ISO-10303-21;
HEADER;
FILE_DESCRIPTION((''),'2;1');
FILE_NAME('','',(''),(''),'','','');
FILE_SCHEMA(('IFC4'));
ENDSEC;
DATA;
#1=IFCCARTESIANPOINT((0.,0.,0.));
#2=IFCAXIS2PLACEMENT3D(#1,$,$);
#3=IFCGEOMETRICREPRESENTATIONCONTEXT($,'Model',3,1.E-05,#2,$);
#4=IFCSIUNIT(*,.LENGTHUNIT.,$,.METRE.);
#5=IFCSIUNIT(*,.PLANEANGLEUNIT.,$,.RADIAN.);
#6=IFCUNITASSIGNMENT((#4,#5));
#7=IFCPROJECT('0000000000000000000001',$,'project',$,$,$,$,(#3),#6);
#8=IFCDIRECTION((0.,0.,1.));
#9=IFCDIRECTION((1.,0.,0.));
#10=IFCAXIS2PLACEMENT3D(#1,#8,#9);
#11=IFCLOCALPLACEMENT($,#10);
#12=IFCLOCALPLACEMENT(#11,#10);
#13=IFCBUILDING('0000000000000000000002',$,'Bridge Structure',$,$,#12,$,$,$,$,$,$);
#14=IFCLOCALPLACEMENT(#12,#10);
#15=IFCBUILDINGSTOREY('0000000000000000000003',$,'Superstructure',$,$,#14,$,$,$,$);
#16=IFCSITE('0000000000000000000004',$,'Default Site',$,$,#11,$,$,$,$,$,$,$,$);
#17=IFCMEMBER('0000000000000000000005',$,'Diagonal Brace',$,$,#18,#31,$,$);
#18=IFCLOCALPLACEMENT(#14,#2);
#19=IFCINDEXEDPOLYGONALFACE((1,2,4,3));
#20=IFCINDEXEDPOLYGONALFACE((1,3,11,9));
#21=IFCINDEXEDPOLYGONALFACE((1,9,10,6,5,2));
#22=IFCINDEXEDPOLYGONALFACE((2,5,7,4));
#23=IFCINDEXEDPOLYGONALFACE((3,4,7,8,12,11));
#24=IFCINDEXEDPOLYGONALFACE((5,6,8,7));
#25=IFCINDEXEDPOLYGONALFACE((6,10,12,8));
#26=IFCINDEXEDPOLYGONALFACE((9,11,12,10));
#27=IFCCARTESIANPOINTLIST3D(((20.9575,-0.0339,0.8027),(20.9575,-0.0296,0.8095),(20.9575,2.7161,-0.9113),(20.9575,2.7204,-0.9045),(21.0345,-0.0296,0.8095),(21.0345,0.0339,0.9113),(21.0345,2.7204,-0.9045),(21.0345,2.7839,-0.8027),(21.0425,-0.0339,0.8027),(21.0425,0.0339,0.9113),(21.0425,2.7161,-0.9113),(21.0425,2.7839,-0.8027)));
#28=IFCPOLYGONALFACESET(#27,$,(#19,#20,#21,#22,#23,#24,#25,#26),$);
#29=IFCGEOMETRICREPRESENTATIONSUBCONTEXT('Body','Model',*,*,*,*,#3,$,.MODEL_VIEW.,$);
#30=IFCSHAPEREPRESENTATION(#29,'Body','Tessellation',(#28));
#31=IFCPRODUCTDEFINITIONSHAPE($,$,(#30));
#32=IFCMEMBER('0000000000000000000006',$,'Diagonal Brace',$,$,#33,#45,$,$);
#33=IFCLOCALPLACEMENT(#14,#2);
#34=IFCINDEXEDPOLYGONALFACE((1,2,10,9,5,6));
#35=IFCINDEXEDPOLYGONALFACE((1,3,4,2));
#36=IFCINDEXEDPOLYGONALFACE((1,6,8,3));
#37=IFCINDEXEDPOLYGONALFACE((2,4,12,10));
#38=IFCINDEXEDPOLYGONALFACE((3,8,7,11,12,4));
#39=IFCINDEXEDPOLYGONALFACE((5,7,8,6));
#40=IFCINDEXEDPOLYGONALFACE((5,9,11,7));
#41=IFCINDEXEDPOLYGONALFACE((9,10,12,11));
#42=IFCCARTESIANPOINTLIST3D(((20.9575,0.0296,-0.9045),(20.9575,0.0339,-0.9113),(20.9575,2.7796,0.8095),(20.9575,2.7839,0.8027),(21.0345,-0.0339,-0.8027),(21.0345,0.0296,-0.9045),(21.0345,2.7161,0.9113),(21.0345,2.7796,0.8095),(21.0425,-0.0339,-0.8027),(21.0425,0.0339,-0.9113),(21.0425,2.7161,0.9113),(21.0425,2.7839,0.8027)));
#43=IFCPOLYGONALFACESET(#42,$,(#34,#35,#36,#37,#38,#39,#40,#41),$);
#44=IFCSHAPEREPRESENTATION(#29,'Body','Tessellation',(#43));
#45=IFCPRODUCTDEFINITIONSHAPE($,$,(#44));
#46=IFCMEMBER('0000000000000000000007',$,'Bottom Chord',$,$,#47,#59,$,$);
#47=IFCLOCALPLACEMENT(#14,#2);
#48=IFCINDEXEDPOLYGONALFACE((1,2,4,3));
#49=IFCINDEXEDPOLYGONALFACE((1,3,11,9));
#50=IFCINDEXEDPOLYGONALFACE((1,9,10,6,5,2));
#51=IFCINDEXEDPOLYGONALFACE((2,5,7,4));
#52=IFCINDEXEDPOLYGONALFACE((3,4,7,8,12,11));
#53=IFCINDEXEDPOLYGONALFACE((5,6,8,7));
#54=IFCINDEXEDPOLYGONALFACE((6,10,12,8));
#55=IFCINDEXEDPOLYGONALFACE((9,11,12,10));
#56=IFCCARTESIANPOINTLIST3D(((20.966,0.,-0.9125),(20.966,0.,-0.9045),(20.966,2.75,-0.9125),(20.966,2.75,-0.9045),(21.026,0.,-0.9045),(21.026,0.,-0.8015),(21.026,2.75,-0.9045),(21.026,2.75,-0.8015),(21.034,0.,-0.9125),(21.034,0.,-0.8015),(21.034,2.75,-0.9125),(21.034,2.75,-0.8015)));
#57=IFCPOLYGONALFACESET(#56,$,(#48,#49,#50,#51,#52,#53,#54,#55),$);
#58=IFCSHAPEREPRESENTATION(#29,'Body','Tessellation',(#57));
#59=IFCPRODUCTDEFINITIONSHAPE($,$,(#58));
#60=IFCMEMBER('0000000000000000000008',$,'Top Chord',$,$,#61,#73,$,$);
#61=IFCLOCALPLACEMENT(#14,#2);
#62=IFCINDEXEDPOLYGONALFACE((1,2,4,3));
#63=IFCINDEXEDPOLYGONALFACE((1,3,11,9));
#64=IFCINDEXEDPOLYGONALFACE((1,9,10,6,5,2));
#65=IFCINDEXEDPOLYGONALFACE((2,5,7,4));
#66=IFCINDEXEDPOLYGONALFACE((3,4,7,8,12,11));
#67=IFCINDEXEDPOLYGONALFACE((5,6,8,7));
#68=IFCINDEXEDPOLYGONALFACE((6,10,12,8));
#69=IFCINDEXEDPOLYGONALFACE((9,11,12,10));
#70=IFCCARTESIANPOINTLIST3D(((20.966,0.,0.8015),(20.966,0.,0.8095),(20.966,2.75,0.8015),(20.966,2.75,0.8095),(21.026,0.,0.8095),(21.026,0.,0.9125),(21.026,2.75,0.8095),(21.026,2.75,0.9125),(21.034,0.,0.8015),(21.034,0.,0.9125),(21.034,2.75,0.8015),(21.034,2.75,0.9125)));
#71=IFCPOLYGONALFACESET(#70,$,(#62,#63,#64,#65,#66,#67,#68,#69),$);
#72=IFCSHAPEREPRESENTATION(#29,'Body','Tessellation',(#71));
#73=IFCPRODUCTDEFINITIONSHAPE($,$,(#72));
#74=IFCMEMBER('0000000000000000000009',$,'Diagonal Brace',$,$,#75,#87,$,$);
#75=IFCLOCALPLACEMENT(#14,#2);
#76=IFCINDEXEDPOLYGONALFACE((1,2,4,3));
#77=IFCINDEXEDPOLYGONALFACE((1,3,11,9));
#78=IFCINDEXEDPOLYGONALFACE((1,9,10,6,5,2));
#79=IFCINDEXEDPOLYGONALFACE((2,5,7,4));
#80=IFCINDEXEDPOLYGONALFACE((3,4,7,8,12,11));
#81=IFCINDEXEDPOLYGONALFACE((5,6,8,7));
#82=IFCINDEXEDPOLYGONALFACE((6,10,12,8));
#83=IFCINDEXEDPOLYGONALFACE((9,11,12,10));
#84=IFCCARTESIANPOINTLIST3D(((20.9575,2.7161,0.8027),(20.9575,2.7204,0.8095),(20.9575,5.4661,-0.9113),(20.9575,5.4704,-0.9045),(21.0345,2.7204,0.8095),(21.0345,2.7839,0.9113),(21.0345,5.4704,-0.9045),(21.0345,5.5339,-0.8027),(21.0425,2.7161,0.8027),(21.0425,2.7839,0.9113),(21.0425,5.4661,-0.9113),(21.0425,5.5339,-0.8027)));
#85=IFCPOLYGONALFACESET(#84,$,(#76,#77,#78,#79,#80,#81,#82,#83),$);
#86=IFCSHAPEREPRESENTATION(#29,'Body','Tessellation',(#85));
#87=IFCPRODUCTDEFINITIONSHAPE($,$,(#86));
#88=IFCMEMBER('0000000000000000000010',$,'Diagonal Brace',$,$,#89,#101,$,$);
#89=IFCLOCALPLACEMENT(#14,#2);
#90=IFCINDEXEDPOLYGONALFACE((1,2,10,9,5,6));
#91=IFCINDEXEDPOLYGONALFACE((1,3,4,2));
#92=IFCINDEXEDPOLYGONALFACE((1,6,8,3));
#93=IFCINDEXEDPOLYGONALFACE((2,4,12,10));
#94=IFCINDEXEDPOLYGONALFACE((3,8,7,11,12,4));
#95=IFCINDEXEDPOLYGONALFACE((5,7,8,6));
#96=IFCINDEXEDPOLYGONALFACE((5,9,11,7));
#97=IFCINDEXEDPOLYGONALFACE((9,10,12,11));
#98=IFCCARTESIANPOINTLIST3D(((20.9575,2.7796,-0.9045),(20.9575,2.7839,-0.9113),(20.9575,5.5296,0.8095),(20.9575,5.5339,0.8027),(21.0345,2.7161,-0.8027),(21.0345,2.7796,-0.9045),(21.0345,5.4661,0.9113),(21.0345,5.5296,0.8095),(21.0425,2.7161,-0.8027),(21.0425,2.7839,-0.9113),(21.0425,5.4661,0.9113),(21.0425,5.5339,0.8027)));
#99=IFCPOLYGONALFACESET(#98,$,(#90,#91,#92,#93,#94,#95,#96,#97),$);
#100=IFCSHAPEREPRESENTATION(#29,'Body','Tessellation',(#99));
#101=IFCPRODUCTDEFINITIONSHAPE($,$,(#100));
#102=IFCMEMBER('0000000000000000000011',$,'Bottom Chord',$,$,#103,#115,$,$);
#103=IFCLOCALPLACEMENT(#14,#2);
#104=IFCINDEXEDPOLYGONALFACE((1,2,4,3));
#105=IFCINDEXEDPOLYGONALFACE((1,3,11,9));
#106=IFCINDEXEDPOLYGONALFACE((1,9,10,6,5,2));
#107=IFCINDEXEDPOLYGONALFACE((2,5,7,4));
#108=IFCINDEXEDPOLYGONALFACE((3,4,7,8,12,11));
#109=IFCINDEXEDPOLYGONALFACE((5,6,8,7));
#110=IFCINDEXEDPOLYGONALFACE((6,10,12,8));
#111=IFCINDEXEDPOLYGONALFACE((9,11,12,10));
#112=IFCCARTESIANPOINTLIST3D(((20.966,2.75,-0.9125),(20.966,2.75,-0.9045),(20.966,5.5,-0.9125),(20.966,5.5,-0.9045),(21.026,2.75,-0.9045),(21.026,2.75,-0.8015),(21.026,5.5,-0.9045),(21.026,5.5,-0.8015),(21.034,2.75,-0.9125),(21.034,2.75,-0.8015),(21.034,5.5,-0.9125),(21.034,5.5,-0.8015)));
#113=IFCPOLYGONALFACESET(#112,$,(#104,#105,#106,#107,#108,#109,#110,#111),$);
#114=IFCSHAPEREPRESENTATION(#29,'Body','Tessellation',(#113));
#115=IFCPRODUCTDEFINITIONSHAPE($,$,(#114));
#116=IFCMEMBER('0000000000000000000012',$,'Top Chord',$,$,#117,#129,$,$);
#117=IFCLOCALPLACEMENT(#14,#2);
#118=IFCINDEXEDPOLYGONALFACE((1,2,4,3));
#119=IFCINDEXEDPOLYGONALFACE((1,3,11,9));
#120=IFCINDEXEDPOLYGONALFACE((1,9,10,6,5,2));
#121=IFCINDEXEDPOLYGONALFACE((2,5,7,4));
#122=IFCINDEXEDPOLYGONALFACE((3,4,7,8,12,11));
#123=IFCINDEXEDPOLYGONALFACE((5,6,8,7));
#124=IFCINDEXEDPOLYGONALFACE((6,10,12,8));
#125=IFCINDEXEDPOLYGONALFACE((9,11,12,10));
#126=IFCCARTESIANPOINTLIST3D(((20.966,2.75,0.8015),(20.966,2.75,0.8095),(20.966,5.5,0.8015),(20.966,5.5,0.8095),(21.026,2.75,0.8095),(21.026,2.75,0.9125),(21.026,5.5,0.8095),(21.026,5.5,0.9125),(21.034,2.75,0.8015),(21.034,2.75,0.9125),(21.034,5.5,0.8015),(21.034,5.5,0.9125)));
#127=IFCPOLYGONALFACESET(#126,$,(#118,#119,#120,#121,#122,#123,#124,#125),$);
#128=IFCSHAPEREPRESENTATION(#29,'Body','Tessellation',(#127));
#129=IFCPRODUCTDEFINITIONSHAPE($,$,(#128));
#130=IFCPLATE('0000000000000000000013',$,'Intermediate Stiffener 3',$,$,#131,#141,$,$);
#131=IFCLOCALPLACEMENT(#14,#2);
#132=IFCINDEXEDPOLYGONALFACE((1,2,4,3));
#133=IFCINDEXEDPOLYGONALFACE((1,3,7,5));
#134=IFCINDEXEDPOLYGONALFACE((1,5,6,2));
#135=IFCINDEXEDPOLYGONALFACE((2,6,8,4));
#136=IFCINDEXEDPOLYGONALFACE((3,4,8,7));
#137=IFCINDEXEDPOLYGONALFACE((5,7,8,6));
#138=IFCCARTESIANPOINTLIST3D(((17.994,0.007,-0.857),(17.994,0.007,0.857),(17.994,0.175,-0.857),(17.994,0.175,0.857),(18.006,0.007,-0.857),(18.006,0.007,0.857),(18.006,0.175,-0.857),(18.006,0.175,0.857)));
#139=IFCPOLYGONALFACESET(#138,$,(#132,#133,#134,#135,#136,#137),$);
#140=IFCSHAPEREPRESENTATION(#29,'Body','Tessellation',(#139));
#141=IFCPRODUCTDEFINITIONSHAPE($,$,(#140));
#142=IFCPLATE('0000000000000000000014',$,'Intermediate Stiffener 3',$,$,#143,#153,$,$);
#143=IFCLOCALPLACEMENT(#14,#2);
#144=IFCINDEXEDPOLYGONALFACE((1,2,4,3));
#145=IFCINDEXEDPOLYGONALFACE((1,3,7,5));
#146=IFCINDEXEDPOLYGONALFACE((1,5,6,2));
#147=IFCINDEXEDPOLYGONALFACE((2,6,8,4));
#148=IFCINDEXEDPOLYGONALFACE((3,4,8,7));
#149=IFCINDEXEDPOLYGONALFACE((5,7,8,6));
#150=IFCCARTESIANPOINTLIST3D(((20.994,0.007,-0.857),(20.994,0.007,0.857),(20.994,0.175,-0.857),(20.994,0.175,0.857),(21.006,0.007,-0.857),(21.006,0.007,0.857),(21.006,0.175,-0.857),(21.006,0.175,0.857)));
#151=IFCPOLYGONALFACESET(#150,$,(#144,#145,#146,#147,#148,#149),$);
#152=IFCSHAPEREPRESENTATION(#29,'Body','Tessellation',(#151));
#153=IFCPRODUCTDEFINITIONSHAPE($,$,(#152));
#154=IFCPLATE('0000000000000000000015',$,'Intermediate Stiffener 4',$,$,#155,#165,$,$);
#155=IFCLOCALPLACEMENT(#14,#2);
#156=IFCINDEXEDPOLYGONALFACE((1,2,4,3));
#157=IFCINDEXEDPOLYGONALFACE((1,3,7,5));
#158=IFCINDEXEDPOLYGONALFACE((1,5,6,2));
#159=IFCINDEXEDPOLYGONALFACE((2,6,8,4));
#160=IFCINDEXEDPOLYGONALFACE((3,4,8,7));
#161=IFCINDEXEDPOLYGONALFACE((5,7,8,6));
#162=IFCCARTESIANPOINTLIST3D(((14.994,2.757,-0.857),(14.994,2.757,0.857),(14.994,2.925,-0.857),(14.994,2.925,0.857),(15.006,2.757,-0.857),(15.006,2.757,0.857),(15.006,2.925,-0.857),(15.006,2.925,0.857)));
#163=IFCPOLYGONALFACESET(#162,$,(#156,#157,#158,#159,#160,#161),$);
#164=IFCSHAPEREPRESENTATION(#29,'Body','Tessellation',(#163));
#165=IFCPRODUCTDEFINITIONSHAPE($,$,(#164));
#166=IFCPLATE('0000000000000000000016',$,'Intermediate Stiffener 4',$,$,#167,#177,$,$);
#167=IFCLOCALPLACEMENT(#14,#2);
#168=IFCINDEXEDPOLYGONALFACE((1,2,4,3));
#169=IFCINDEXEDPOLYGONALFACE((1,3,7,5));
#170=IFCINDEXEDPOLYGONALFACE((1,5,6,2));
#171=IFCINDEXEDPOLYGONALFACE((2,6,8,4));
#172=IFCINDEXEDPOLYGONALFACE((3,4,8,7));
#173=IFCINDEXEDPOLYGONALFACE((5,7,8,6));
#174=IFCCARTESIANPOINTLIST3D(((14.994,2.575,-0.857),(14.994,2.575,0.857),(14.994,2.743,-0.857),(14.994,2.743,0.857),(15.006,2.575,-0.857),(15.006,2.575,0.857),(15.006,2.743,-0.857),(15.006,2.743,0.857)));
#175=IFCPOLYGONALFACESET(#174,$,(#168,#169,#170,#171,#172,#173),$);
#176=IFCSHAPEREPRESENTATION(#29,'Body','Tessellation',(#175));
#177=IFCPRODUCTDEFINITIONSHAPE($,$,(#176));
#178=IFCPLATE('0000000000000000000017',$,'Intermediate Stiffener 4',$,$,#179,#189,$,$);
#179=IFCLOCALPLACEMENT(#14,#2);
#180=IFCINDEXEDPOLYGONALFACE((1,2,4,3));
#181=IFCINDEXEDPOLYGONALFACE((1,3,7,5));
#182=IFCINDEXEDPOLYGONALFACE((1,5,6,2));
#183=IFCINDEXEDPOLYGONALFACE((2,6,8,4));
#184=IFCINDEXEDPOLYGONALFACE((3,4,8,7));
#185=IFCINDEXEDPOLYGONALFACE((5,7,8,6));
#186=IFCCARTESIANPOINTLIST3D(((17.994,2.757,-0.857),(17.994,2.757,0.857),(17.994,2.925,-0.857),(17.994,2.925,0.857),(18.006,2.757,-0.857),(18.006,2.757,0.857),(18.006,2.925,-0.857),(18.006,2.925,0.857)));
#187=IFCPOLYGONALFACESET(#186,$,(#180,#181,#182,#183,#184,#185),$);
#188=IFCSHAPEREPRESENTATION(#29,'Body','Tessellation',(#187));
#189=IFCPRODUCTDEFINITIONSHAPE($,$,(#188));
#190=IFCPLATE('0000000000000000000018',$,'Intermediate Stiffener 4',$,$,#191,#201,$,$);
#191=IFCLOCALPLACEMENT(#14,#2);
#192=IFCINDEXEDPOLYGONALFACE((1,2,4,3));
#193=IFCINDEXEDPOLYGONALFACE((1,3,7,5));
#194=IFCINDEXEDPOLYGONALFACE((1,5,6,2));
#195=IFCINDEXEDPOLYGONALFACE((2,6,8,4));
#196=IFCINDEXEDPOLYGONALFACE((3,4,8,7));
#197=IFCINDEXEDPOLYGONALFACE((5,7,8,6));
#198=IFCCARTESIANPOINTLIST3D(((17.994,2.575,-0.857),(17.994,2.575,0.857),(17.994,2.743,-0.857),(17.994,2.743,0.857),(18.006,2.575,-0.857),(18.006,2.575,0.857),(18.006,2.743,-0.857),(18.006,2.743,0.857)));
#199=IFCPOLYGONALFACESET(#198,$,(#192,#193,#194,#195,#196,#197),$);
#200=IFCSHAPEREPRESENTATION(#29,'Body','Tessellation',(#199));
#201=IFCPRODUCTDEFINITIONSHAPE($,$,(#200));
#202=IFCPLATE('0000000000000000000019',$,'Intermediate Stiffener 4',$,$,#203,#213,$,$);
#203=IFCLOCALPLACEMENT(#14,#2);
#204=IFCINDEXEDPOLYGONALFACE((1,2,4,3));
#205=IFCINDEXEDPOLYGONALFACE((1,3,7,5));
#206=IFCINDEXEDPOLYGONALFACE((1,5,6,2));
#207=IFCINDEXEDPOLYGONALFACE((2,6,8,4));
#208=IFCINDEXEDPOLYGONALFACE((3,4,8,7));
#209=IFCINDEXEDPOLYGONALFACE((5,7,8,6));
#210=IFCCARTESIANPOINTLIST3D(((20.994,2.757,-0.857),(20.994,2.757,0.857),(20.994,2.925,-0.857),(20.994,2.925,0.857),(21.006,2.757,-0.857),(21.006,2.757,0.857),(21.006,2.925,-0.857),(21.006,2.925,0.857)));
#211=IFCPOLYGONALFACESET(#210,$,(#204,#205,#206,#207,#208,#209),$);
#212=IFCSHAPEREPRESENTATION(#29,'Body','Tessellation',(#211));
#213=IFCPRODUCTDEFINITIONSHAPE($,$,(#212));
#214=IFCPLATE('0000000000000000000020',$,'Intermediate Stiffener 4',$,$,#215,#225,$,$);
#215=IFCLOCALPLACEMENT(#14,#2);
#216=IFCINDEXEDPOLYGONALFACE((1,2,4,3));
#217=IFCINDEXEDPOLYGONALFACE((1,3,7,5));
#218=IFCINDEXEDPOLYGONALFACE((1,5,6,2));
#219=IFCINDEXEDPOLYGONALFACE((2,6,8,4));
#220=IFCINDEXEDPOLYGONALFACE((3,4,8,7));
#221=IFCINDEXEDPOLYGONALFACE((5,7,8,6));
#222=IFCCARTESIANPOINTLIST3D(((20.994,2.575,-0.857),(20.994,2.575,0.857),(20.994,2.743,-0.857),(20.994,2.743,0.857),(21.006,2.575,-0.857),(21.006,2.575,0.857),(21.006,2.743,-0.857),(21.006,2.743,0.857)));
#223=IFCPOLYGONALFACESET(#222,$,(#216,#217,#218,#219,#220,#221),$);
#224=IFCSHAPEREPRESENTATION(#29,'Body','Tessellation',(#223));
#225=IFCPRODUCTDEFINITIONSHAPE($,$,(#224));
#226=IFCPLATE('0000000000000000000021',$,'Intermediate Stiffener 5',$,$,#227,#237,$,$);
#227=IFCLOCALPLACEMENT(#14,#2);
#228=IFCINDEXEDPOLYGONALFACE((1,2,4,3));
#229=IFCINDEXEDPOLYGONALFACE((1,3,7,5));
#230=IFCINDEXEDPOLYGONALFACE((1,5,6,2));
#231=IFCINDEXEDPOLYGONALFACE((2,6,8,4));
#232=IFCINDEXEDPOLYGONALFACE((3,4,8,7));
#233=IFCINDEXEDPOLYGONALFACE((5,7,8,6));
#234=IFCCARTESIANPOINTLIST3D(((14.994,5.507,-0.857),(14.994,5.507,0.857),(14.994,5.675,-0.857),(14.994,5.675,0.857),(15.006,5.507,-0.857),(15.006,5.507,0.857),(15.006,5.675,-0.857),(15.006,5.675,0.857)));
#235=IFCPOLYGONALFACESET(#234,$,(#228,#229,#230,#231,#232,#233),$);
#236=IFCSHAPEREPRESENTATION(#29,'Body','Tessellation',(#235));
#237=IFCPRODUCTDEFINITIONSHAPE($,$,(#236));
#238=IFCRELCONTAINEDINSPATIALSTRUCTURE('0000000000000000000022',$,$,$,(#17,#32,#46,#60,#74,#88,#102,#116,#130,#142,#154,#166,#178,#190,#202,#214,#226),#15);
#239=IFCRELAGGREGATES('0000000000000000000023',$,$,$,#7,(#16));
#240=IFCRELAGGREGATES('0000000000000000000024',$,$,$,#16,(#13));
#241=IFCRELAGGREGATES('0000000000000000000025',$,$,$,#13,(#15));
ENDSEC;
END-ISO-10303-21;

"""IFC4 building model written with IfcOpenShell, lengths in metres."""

from ifc_helpers import new_model, si_unit, frame, origin, origin_with_axes, origin_2d_with_axis, place, context, subcontext, project, spatial, rectangle, l_section, extrude, element, save


model = new_model("IFC4")

# Units and contexts
model_context = context("Model", 3, precision=1e-05, world=origin())
body_context = subcontext(model_context, "Body", "Model", "MODEL_VIEW")
ifc_project = project(units=[si_unit("LENGTHUNIT", "METRE"), si_unit("PLANEANGLEUNIT", "RADIAN")], contexts=[model_context])

# Site, building, storey
site_placement = place(None, origin_with_axes())
site = spatial("IfcSite", under=ifc_project, at=site_placement, Name="Default Site")
building_placement = place(site_placement, origin_with_axes())
building = spatial("IfcBuilding", under=site, at=building_placement, Name="Bridge Structure")
storey_placement = place(building_placement, origin_with_axes())
storey = spatial("IfcBuildingStorey", under=building, at=storey_placement, Name="Superstructure")

# Members
for number, where, z_axis, x_axis, name in (
    (1, (21.0, 0.0, 0.857), (0.0, 0.848656, -0.528944), (-1.0, 0.0, 0.0), "Diagonal Brace"),
    (2, (21.0, 0.0, -0.857), (0.0, 0.848656, 0.528944), (-1.0, 0.0, 0.0), "Diagonal Brace"),
):
    element("IfcMember", number, at=place(storey_placement, frame(where, z_axis=z_axis, x_axis=x_axis)), inside=storey, Name=name, context=body_context, shape_type="SweptSolid", body=[
        extrude(l_section(Depth=0.128, Width=0.085, Thickness=0.008, at=origin_2d_with_axis()), origin_with_axes(), (0.0, 0.0, 1.0), 3.2404),
    ])
for number, where, z_axis, x_axis, name in (
    (3, (21.0, 0.0, -0.857), (0.0, 1.0, 0.0), (-1.0, 0.0, 0.0), "Bottom Chord"),
    (4, (21.0, 0.0, 0.857), (0.0, 1.0, 0.0), (-1.0, 0.0, 0.0), "Top Chord"),
):
    element("IfcMember", number, at=place(storey_placement, frame(where, z_axis=z_axis, x_axis=x_axis)), inside=storey, Name=name, context=body_context, shape_type="SweptSolid", body=[
        extrude(l_section(Depth=0.111, Width=0.068, Thickness=0.008, at=origin_2d_with_axis()), origin_with_axes(), (0.0, 0.0, 1.0), 2.75),
    ])
for number, where, z_axis, x_axis, name in (
    (5, (21.0, 2.75, 0.857), (0.0, 0.848656, -0.528944), (-1.0, 0.0, 0.0), "Diagonal Brace"),
    (6, (21.0, 2.75, -0.857), (0.0, 0.848656, 0.528944), (-1.0, 0.0, 0.0), "Diagonal Brace"),
):
    element("IfcMember", number, at=place(storey_placement, frame(where, z_axis=z_axis, x_axis=x_axis)), inside=storey, Name=name, context=body_context, shape_type="SweptSolid", body=[
        extrude(l_section(Depth=0.128, Width=0.085, Thickness=0.008, at=origin_2d_with_axis()), origin_with_axes(), (0.0, 0.0, 1.0), 3.2404),
    ])
for number, where, z_axis, x_axis, name in (
    (7, (21.0, 2.75, -0.857), (0.0, 1.0, 0.0), (-1.0, 0.0, 0.0), "Bottom Chord"),
    (8, (21.0, 2.75, 0.857), (0.0, 1.0, 0.0), (-1.0, 0.0, 0.0), "Top Chord"),
):
    element("IfcMember", number, at=place(storey_placement, frame(where, z_axis=z_axis, x_axis=x_axis)), inside=storey, Name=name, context=body_context, shape_type="SweptSolid", body=[
        extrude(l_section(Depth=0.111, Width=0.068, Thickness=0.008, at=origin_2d_with_axis()), origin_with_axes(), (0.0, 0.0, 1.0), 2.75),
    ])

# Plates
for number, where, z_axis, x_axis, name in (
    (9, (18.0, 0.091, -0.857), (0.0, 0.0, 1.0), (1.0, 0.0, 0.0), "Intermediate Stiffener 3"),
    (10, (21.0, 0.091, -0.857), (0.0, 0.0, 1.0), (1.0, 0.0, 0.0), "Intermediate Stiffener 3"),
    (11, (15.0, 2.841, -0.857), (0.0, 0.0, 1.0), (1.0, 0.0, 0.0), "Intermediate Stiffener 4"),
    (12, (15.0, 2.659, -0.857), (0.0, 0.0, 1.0), (1.0, 0.0, 0.0), "Intermediate Stiffener 4"),
    (13, (18.0, 2.841, -0.857), (0.0, 0.0, 1.0), (1.0, 0.0, 0.0), "Intermediate Stiffener 4"),
    (14, (18.0, 2.659, -0.857), (0.0, 0.0, 1.0), (1.0, 0.0, 0.0), "Intermediate Stiffener 4"),
    (15, (21.0, 2.841, -0.857), (0.0, 0.0, 1.0), (1.0, 0.0, 0.0), "Intermediate Stiffener 4"),
    (16, (21.0, 2.659, -0.857), (0.0, 0.0, 1.0), (1.0, 0.0, 0.0), "Intermediate Stiffener 4"),
    (17, (15.0, 5.591, -0.857), (0.0, 0.0, 1.0), (1.0, 0.0, 0.0), "Intermediate Stiffener 5"),
):
    element("IfcPlate", number, at=place(storey_placement, frame(where, z_axis=z_axis, x_axis=x_axis)), inside=storey, Name=name, context=body_context, shape_type="SweptSolid", body=[
        extrude(rectangle(XDim=0.012, YDim=0.168, at=origin_2d_with_axis()), origin_with_axes(), (0.0, 0.0, 1.0), 1.714),
    ])

save(model, "model.ifc")
